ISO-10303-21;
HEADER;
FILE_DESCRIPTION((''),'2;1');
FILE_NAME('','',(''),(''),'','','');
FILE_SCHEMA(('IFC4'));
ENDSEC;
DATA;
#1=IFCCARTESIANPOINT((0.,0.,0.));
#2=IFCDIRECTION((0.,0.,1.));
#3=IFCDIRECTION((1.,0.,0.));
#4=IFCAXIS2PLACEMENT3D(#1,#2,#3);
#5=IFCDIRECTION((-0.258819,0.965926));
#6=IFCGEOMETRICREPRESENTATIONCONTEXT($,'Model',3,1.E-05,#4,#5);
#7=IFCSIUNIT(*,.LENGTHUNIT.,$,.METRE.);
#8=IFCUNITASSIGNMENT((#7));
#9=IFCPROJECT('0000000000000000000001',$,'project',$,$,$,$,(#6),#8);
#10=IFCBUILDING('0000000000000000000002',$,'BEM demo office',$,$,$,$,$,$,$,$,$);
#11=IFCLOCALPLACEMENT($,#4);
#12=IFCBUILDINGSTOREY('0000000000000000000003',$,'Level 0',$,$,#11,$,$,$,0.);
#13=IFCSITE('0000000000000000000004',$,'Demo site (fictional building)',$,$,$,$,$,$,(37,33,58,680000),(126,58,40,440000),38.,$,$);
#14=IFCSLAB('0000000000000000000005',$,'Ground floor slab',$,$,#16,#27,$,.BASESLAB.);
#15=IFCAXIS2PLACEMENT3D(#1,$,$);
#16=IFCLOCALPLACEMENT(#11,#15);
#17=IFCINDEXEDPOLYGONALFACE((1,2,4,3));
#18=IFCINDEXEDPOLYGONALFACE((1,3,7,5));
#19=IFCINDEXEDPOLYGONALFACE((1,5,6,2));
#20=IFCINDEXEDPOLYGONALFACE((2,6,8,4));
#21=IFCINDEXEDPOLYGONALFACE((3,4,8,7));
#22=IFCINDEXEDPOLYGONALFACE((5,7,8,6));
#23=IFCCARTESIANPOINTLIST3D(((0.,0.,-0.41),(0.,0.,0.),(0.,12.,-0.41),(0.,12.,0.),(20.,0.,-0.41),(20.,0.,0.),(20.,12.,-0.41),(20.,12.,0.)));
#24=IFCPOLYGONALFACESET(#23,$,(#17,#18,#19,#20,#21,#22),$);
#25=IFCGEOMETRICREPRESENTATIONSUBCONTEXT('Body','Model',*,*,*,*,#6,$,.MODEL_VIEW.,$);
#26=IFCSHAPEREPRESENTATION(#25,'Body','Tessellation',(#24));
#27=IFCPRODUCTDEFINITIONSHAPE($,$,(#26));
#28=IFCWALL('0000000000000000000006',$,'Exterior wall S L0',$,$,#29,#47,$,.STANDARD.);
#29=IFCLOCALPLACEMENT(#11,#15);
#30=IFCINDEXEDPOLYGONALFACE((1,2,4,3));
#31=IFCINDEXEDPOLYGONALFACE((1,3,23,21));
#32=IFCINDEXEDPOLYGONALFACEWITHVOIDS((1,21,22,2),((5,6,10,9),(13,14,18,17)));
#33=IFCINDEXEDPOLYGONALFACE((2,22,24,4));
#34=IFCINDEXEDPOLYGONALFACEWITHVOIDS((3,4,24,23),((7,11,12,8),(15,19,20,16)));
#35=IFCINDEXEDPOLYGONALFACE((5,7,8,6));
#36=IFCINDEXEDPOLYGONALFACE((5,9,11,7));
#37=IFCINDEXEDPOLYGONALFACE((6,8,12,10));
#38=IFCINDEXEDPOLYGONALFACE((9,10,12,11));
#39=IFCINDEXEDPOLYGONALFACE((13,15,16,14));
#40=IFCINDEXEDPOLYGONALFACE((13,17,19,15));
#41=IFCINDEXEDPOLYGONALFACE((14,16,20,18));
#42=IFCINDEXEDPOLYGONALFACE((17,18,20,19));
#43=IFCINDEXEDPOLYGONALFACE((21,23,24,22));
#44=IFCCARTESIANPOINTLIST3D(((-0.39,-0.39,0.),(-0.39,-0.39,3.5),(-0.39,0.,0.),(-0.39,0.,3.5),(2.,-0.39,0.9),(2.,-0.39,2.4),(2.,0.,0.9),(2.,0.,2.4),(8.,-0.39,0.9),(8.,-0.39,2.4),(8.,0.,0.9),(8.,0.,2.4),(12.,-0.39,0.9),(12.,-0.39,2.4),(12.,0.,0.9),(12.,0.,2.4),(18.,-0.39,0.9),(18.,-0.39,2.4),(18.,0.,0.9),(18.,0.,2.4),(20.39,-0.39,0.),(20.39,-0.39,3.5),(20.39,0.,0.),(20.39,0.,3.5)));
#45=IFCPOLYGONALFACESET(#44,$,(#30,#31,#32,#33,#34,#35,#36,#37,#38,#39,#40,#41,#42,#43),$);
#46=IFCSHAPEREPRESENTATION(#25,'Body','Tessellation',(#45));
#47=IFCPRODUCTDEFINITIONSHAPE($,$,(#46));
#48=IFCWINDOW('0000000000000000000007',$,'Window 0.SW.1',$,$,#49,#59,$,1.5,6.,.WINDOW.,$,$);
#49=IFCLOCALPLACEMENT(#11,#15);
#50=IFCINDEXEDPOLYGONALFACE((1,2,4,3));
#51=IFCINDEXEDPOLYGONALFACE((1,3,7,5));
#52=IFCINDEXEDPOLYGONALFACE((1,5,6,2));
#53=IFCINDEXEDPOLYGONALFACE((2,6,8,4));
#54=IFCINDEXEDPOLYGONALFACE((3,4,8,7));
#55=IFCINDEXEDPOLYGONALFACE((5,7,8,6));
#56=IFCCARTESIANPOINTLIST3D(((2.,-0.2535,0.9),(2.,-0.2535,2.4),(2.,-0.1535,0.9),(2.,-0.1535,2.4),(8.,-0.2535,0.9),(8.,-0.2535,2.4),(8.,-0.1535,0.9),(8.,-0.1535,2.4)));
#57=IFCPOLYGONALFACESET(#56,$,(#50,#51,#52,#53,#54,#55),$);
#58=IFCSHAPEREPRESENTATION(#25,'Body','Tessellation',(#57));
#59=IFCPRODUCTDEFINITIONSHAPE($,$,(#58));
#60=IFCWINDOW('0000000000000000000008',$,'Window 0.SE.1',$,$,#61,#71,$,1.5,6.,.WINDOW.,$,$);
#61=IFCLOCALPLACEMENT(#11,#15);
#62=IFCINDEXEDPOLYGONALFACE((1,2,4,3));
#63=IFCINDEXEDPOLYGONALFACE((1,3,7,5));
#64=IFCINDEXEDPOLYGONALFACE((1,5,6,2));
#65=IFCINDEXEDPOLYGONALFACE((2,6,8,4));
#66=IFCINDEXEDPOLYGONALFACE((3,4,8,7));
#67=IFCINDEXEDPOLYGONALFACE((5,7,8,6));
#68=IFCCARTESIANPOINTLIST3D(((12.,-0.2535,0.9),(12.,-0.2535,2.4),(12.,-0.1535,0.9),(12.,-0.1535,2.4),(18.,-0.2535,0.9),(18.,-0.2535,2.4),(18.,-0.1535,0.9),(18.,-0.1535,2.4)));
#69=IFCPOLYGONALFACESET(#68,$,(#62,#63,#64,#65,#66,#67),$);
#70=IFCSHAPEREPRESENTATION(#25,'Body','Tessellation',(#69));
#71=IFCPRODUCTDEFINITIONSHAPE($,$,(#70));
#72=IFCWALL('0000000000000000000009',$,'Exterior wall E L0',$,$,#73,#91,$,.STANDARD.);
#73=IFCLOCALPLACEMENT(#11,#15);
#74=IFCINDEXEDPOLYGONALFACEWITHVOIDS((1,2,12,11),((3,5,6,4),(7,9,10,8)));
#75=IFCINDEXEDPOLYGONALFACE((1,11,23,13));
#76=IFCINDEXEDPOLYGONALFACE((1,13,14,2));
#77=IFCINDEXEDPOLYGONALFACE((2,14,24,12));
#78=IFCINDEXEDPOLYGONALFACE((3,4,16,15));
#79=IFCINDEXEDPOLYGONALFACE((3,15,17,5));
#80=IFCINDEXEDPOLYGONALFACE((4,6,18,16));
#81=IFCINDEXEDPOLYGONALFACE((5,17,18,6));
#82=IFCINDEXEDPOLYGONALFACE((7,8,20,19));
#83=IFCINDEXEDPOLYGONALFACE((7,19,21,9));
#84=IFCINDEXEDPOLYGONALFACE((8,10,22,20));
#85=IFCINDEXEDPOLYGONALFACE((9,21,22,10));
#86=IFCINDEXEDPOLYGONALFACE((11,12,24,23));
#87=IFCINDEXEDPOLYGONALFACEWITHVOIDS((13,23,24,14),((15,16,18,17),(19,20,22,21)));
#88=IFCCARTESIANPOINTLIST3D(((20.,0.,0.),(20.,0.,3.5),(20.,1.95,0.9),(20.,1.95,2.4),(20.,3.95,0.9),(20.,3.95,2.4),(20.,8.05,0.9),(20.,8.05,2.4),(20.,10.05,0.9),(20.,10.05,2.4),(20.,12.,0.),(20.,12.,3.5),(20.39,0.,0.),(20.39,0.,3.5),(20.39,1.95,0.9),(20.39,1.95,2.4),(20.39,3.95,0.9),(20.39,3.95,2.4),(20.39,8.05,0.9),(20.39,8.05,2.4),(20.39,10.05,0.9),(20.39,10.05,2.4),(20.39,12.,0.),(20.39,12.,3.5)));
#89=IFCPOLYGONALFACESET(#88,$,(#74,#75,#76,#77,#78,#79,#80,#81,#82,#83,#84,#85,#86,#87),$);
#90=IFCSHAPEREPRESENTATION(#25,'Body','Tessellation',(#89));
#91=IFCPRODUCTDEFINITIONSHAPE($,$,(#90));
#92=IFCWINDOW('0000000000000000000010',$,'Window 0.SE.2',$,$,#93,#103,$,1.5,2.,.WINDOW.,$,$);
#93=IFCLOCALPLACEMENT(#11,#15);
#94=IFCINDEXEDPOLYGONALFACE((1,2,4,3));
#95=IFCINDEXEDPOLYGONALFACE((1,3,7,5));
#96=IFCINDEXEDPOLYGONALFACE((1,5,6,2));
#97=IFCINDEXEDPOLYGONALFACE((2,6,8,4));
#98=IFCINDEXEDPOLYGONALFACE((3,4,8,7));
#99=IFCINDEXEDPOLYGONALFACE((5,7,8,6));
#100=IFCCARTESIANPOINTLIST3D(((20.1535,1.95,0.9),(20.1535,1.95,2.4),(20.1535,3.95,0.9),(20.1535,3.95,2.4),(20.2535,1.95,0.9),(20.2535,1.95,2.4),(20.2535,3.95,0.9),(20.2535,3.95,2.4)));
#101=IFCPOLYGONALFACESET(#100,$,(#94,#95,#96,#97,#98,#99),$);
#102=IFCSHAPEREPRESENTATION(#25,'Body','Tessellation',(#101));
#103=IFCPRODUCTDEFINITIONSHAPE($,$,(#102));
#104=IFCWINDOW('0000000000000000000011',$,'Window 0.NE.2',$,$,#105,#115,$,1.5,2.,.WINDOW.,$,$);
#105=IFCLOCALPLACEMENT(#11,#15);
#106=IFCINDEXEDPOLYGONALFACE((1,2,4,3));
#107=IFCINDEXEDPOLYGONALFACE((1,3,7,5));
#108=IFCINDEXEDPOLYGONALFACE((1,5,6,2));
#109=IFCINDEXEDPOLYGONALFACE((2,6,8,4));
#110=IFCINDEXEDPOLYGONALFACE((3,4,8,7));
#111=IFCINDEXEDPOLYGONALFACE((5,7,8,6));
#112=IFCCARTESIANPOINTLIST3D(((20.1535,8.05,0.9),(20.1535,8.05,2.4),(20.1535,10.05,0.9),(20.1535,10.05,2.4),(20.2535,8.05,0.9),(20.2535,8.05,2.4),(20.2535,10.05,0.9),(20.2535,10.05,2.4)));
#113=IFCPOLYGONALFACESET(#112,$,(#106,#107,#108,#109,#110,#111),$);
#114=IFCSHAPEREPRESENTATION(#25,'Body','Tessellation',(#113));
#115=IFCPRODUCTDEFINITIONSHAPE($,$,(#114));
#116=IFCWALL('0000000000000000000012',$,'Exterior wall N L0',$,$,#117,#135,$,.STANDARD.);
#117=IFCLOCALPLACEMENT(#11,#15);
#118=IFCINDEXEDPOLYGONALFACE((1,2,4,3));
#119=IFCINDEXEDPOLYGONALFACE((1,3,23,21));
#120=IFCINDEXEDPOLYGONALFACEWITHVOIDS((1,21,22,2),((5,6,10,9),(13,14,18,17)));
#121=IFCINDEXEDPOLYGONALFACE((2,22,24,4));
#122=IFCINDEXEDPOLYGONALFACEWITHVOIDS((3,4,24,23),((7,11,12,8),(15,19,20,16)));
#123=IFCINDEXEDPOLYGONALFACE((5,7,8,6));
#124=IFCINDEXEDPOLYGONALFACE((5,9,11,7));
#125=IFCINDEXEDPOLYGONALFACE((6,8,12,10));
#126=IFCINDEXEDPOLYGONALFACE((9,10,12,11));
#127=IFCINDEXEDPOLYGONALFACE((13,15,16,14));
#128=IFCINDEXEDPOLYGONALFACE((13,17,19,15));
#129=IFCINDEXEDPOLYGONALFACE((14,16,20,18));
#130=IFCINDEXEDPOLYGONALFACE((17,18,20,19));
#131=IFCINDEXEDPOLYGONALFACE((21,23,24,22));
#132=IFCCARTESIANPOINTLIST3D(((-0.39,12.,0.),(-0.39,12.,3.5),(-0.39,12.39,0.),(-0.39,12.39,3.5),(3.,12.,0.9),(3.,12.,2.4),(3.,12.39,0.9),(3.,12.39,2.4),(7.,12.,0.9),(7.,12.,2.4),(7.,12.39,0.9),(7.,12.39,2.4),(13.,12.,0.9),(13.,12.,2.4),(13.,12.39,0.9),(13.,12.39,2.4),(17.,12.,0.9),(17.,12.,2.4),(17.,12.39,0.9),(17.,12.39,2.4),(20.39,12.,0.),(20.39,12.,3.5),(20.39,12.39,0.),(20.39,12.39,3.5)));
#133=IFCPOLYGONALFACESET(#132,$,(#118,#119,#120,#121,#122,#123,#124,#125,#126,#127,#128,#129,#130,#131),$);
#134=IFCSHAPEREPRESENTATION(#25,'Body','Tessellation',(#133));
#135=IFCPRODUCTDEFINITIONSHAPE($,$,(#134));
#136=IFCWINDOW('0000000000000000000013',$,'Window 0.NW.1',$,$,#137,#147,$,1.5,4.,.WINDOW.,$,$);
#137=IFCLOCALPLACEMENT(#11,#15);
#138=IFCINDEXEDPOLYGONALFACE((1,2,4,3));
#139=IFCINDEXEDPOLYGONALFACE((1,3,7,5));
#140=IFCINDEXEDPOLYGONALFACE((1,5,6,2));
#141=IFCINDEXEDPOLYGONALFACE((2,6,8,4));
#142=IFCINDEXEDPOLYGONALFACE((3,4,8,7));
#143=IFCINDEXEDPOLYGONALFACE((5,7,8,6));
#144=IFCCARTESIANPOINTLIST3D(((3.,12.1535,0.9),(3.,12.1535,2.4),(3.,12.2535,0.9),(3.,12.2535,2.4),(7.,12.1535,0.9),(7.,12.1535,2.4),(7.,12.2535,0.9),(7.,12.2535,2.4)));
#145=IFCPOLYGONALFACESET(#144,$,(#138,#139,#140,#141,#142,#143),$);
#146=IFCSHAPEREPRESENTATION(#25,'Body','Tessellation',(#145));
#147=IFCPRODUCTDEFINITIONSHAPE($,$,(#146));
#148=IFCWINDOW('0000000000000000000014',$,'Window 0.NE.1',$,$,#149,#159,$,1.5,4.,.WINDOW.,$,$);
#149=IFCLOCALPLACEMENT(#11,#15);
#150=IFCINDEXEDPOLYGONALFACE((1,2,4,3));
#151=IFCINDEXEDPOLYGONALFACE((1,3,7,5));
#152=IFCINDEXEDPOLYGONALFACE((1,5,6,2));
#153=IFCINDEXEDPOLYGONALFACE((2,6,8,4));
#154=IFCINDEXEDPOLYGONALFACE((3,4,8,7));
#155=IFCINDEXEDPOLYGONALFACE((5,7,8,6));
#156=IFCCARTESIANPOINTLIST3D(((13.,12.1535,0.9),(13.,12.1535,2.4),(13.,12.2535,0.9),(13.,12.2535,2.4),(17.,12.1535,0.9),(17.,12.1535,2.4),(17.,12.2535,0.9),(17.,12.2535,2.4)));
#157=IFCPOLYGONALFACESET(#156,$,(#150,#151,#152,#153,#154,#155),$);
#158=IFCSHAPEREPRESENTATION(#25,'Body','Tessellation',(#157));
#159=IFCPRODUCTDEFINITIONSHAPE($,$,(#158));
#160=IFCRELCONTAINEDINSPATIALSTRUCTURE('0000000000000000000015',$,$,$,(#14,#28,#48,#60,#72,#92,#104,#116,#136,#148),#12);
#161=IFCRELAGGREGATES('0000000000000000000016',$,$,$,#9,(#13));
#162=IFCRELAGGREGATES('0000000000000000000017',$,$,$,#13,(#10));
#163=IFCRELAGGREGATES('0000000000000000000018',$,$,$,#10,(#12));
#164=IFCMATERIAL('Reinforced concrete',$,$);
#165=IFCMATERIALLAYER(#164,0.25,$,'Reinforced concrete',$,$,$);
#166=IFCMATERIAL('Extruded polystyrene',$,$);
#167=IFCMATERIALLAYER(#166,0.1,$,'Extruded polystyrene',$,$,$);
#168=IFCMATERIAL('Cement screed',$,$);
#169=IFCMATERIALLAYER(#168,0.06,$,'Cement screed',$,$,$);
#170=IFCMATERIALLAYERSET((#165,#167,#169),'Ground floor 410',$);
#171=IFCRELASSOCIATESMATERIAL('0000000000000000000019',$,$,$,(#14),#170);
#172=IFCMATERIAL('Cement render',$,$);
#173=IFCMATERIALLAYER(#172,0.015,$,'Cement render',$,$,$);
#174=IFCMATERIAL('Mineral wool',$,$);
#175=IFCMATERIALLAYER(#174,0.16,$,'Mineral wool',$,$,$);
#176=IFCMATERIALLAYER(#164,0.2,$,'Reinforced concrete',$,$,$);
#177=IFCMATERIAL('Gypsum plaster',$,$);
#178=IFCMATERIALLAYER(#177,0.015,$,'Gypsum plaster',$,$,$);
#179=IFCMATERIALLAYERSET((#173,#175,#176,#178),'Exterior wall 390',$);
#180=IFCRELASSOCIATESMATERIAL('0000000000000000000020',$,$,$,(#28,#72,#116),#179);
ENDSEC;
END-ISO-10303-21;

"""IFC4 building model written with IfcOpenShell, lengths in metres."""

from ifc_helpers import new_model, si_unit, direction, frame, frame_2d, origin, origin_with_axes, place, context, subcontext, project, spatial, rectangle, extrude, material, layer, layer_set, layer_usage, element, fill, save


model = new_model("IFC4")

# Units and contexts
model_context = context("Model", 3, precision=1e-05, world=origin_with_axes(), true_north=direction((-0.258819, 0.965926)))
body_context = subcontext(model_context, "Body", "Model", "MODEL_VIEW")
ifc_project = project(units=[si_unit("LENGTHUNIT", "METRE")], contexts=[model_context])

# Site, building, storey
site = spatial("IfcSite", under=ifc_project, Name="Demo site (fictional building)", RefLatitude=(37, 33, 58, 680000), RefLongitude=(126, 58, 40, 440000), RefElevation=38.0)
building = spatial("IfcBuilding", under=site, Name="BEM demo office")
storey_placement = place(None, origin_with_axes())
storey = spatial("IfcBuildingStorey", under=building, at=storey_placement, Name="Level 0", Elevation=0.0)

# Slab
ifc_material_1 = material(Name="Reinforced concrete")
ifc_layer_1 = layer(ifc_material_1, 0.25, Name="Reinforced concrete")
ifc_material_2 = material(Name="Extruded polystyrene")
ifc_layer_2 = layer(ifc_material_2, 0.1, Name="Extruded polystyrene")
ifc_material_3 = material(Name="Cement screed")
ifc_layer_3 = layer(ifc_material_3, 0.06, Name="Cement screed")
ifc_layer_set_1 = layer_set([ifc_layer_1, ifc_layer_2, ifc_layer_3], Name="Ground floor 410")
ifc_layer_usage_1 = layer_usage(ifc_layer_set_1, "AXIS3", "POSITIVE", 0.0)
slab_placement = place(storey_placement, frame((0.0, 0.0, -0.41), z_axis=(0.0, 0.0, 1.0), x_axis=(1.0, 0.0, 0.0)))
element("IfcSlab", 1, at=slab_placement, inside=storey, material=ifc_layer_usage_1, Name="Ground floor slab", PredefinedType="BASESLAB", context=body_context, shape_type="SweptSolid", body=[
    extrude(rectangle(XDim=20.0, YDim=12.0, at=frame_2d((10.0, 6.0))), origin(), (0.0, 0.0, 1.0), 0.41),
])

# Walls, openings, windows
ifc_material_4 = material(Name="Cement render")
ifc_layer_4 = layer(ifc_material_4, 0.015, Name="Cement render")
ifc_material_5 = material(Name="Mineral wool")
ifc_layer_5 = layer(ifc_material_5, 0.16, Name="Mineral wool")
ifc_layer_6 = layer(ifc_material_1, 0.2, Name="Reinforced concrete")
ifc_material_6 = material(Name="Gypsum plaster")
ifc_layer_7 = layer(ifc_material_6, 0.015, Name="Gypsum plaster")
ifc_layer_set_2 = layer_set([ifc_layer_4, ifc_layer_5, ifc_layer_6, ifc_layer_7], Name="Exterior wall 390")
ifc_layer_usage_2 = layer_usage(ifc_layer_set_2, "AXIS2", "POSITIVE", 0.0)
wall_1_placement = place(storey_placement, frame((-0.39, -0.39, 0.0), z_axis=(0.0, 0.0, 1.0), x_axis=(1.0, 0.0, 0.0)))
wall_1 = element("IfcWall", 2, at=wall_1_placement, inside=storey, material=ifc_layer_usage_2, Name="Exterior wall S L0", PredefinedType="STANDARD", context=body_context, shape_type="SweptSolid", body=[
    extrude(rectangle(XDim=20.78, YDim=0.39, at=frame_2d((10.39, 0.195))), origin(), (0.0, 0.0, 1.0), 3.5),
])
opening_1_placement = place(wall_1_placement, origin())
opening_1 = element("IfcOpeningElement", 3, at=opening_1_placement, cuts=wall_1, PredefinedType="OPENING", context=body_context, shape_type="SweptSolid", body=[
    extrude(rectangle(XDim=6.0, YDim=0.49, at=frame_2d((3.0, 0.245))), frame((2.39, -0.05, 0.9)), (0.0, 0.0, 1.0), 1.5),
])
opening_2_placement = place(wall_1_placement, origin())
opening_2 = element("IfcOpeningElement", 4, at=opening_2_placement, cuts=wall_1, PredefinedType="OPENING", context=body_context, shape_type="SweptSolid", body=[
    extrude(rectangle(XDim=6.0, YDim=0.49, at=frame_2d((3.0, 0.245))), frame((12.39, -0.05, 0.9)), (0.0, 0.0, 1.0), 1.5),
])
window_1_placement = place(opening_1_placement, origin_with_axes())
window_1 = element("IfcWindow", 5, at=window_1_placement, inside=storey, Name="Window 0.SW.1", OverallHeight=1.5, OverallWidth=6.0, PredefinedType="WINDOW", context=body_context, shape_type="SweptSolid", body=[
    extrude(rectangle(XDim=6.0, YDim=0.1, at=frame_2d((3.0, 0.05))), frame((2.39, 0.1365, 0.9)), (0.0, 0.0, 1.0), 1.5),
])
fill(opening_1, window_1)
window_2_placement = place(opening_2_placement, origin_with_axes())
window_2 = element("IfcWindow", 6, at=window_2_placement, inside=storey, Name="Window 0.SE.1", OverallHeight=1.5, OverallWidth=6.0, PredefinedType="WINDOW", context=body_context, shape_type="SweptSolid", body=[
    extrude(rectangle(XDim=6.0, YDim=0.1, at=frame_2d((3.0, 0.05))), frame((12.39, 0.1365, 0.9)), (0.0, 0.0, 1.0), 1.5),
])
fill(opening_2, window_2)
wall_2_placement = place(storey_placement, frame((20.39, 0.0, 0.0), z_axis=(0.0, 0.0, 1.0), x_axis=(0.0, 1.0, 0.0)))
wall_2 = element("IfcWall", 7, at=wall_2_placement, inside=storey, material=ifc_layer_usage_2, Name="Exterior wall E L0", PredefinedType="STANDARD", context=body_context, shape_type="SweptSolid", body=[
    extrude(rectangle(XDim=12.0, YDim=0.39, at=frame_2d((6.0, 0.195))), origin(), (0.0, 0.0, 1.0), 3.5),
])
opening_3_placement = place(wall_2_placement, origin())
opening_3 = element("IfcOpeningElement", 8, at=opening_3_placement, cuts=wall_2, PredefinedType="OPENING", context=body_context, shape_type="SweptSolid", body=[
    extrude(rectangle(XDim=2.0, YDim=0.49, at=frame_2d((1.0, 0.245))), frame((1.95, -0.05, 0.9)), (0.0, 0.0, 1.0), 1.5),
])
opening_4_placement = place(wall_2_placement, origin())
opening_4 = element("IfcOpeningElement", 9, at=opening_4_placement, cuts=wall_2, PredefinedType="OPENING", context=body_context, shape_type="SweptSolid", body=[
    extrude(rectangle(XDim=2.0, YDim=0.49, at=frame_2d((1.0, 0.245))), frame((8.05, -0.05, 0.9)), (0.0, 0.0, 1.0), 1.5),
])
window_3_placement = place(opening_3_placement, origin_with_axes())
window_3 = element("IfcWindow", 10, at=window_3_placement, inside=storey, Name="Window 0.SE.2", OverallHeight=1.5, OverallWidth=2.0, PredefinedType="WINDOW", context=body_context, shape_type="SweptSolid", body=[
    extrude(rectangle(XDim=2.0, YDim=0.1, at=frame_2d((1.0, 0.05))), frame((1.95, 0.1365, 0.9)), (0.0, 0.0, 1.0), 1.5),
])
fill(opening_3, window_3)
window_4_placement = place(opening_4_placement, origin_with_axes())
window_4 = element("IfcWindow", 11, at=window_4_placement, inside=storey, Name="Window 0.NE.2", OverallHeight=1.5, OverallWidth=2.0, PredefinedType="WINDOW", context=body_context, shape_type="SweptSolid", body=[
    extrude(rectangle(XDim=2.0, YDim=0.1, at=frame_2d((1.0, 0.05))), frame((8.05, 0.1365, 0.9)), (0.0, 0.0, 1.0), 1.5),
])
fill(opening_4, window_4)
wall_3_placement = place(storey_placement, frame((20.39, 12.39, 0.0), z_axis=(0.0, 0.0, 1.0), x_axis=(-1.0, 0.0, 0.0)))
wall_3 = element("IfcWall", 12, at=wall_3_placement, inside=storey, material=ifc_layer_usage_2, Name="Exterior wall N L0", PredefinedType="STANDARD", context=body_context, shape_type="SweptSolid", body=[
    extrude(rectangle(XDim=20.78, YDim=0.39, at=frame_2d((10.39, 0.195))), origin(), (0.0, 0.0, 1.0), 3.5),
])
opening_5_placement = place(wall_3_placement, origin())
opening_5 = element("IfcOpeningElement", 13, at=opening_5_placement, cuts=wall_3, PredefinedType="OPENING", context=body_context, shape_type="SweptSolid", body=[
    extrude(rectangle(XDim=4.0, YDim=0.49, at=frame_2d((2.0, 0.245))), frame((13.39, -0.05, 0.9)), (0.0, 0.0, 1.0), 1.5),
])
opening_6_placement = place(wall_3_placement, origin())
opening_6 = element("IfcOpeningElement", 14, at=opening_6_placement, cuts=wall_3, PredefinedType="OPENING", context=body_context, shape_type="SweptSolid", body=[
    extrude(rectangle(XDim=4.0, YDim=0.49, at=frame_2d((2.0, 0.245))), frame((3.39, -0.05, 0.9)), (0.0, 0.0, 1.0), 1.5),
])
window_5_placement = place(opening_5_placement, origin_with_axes())
window_5 = element("IfcWindow", 15, at=window_5_placement, inside=storey, Name="Window 0.NW.1", OverallHeight=1.5, OverallWidth=4.0, PredefinedType="WINDOW", context=body_context, shape_type="SweptSolid", body=[
    extrude(rectangle(XDim=4.0, YDim=0.1, at=frame_2d((2.0, 0.05))), frame((13.39, 0.1365, 0.9)), (0.0, 0.0, 1.0), 1.5),
])
fill(opening_5, window_5)
window_6_placement = place(opening_6_placement, origin_with_axes())
window_6 = element("IfcWindow", 16, at=window_6_placement, inside=storey, Name="Window 0.NE.1", OverallHeight=1.5, OverallWidth=4.0, PredefinedType="WINDOW", context=body_context, shape_type="SweptSolid", body=[
    extrude(rectangle(XDim=4.0, YDim=0.1, at=frame_2d((2.0, 0.05))), frame((3.39, 0.1365, 0.9)), (0.0, 0.0, 1.0), 1.5),
])
fill(opening_6, window_6)

save(model, "model.ifc")
